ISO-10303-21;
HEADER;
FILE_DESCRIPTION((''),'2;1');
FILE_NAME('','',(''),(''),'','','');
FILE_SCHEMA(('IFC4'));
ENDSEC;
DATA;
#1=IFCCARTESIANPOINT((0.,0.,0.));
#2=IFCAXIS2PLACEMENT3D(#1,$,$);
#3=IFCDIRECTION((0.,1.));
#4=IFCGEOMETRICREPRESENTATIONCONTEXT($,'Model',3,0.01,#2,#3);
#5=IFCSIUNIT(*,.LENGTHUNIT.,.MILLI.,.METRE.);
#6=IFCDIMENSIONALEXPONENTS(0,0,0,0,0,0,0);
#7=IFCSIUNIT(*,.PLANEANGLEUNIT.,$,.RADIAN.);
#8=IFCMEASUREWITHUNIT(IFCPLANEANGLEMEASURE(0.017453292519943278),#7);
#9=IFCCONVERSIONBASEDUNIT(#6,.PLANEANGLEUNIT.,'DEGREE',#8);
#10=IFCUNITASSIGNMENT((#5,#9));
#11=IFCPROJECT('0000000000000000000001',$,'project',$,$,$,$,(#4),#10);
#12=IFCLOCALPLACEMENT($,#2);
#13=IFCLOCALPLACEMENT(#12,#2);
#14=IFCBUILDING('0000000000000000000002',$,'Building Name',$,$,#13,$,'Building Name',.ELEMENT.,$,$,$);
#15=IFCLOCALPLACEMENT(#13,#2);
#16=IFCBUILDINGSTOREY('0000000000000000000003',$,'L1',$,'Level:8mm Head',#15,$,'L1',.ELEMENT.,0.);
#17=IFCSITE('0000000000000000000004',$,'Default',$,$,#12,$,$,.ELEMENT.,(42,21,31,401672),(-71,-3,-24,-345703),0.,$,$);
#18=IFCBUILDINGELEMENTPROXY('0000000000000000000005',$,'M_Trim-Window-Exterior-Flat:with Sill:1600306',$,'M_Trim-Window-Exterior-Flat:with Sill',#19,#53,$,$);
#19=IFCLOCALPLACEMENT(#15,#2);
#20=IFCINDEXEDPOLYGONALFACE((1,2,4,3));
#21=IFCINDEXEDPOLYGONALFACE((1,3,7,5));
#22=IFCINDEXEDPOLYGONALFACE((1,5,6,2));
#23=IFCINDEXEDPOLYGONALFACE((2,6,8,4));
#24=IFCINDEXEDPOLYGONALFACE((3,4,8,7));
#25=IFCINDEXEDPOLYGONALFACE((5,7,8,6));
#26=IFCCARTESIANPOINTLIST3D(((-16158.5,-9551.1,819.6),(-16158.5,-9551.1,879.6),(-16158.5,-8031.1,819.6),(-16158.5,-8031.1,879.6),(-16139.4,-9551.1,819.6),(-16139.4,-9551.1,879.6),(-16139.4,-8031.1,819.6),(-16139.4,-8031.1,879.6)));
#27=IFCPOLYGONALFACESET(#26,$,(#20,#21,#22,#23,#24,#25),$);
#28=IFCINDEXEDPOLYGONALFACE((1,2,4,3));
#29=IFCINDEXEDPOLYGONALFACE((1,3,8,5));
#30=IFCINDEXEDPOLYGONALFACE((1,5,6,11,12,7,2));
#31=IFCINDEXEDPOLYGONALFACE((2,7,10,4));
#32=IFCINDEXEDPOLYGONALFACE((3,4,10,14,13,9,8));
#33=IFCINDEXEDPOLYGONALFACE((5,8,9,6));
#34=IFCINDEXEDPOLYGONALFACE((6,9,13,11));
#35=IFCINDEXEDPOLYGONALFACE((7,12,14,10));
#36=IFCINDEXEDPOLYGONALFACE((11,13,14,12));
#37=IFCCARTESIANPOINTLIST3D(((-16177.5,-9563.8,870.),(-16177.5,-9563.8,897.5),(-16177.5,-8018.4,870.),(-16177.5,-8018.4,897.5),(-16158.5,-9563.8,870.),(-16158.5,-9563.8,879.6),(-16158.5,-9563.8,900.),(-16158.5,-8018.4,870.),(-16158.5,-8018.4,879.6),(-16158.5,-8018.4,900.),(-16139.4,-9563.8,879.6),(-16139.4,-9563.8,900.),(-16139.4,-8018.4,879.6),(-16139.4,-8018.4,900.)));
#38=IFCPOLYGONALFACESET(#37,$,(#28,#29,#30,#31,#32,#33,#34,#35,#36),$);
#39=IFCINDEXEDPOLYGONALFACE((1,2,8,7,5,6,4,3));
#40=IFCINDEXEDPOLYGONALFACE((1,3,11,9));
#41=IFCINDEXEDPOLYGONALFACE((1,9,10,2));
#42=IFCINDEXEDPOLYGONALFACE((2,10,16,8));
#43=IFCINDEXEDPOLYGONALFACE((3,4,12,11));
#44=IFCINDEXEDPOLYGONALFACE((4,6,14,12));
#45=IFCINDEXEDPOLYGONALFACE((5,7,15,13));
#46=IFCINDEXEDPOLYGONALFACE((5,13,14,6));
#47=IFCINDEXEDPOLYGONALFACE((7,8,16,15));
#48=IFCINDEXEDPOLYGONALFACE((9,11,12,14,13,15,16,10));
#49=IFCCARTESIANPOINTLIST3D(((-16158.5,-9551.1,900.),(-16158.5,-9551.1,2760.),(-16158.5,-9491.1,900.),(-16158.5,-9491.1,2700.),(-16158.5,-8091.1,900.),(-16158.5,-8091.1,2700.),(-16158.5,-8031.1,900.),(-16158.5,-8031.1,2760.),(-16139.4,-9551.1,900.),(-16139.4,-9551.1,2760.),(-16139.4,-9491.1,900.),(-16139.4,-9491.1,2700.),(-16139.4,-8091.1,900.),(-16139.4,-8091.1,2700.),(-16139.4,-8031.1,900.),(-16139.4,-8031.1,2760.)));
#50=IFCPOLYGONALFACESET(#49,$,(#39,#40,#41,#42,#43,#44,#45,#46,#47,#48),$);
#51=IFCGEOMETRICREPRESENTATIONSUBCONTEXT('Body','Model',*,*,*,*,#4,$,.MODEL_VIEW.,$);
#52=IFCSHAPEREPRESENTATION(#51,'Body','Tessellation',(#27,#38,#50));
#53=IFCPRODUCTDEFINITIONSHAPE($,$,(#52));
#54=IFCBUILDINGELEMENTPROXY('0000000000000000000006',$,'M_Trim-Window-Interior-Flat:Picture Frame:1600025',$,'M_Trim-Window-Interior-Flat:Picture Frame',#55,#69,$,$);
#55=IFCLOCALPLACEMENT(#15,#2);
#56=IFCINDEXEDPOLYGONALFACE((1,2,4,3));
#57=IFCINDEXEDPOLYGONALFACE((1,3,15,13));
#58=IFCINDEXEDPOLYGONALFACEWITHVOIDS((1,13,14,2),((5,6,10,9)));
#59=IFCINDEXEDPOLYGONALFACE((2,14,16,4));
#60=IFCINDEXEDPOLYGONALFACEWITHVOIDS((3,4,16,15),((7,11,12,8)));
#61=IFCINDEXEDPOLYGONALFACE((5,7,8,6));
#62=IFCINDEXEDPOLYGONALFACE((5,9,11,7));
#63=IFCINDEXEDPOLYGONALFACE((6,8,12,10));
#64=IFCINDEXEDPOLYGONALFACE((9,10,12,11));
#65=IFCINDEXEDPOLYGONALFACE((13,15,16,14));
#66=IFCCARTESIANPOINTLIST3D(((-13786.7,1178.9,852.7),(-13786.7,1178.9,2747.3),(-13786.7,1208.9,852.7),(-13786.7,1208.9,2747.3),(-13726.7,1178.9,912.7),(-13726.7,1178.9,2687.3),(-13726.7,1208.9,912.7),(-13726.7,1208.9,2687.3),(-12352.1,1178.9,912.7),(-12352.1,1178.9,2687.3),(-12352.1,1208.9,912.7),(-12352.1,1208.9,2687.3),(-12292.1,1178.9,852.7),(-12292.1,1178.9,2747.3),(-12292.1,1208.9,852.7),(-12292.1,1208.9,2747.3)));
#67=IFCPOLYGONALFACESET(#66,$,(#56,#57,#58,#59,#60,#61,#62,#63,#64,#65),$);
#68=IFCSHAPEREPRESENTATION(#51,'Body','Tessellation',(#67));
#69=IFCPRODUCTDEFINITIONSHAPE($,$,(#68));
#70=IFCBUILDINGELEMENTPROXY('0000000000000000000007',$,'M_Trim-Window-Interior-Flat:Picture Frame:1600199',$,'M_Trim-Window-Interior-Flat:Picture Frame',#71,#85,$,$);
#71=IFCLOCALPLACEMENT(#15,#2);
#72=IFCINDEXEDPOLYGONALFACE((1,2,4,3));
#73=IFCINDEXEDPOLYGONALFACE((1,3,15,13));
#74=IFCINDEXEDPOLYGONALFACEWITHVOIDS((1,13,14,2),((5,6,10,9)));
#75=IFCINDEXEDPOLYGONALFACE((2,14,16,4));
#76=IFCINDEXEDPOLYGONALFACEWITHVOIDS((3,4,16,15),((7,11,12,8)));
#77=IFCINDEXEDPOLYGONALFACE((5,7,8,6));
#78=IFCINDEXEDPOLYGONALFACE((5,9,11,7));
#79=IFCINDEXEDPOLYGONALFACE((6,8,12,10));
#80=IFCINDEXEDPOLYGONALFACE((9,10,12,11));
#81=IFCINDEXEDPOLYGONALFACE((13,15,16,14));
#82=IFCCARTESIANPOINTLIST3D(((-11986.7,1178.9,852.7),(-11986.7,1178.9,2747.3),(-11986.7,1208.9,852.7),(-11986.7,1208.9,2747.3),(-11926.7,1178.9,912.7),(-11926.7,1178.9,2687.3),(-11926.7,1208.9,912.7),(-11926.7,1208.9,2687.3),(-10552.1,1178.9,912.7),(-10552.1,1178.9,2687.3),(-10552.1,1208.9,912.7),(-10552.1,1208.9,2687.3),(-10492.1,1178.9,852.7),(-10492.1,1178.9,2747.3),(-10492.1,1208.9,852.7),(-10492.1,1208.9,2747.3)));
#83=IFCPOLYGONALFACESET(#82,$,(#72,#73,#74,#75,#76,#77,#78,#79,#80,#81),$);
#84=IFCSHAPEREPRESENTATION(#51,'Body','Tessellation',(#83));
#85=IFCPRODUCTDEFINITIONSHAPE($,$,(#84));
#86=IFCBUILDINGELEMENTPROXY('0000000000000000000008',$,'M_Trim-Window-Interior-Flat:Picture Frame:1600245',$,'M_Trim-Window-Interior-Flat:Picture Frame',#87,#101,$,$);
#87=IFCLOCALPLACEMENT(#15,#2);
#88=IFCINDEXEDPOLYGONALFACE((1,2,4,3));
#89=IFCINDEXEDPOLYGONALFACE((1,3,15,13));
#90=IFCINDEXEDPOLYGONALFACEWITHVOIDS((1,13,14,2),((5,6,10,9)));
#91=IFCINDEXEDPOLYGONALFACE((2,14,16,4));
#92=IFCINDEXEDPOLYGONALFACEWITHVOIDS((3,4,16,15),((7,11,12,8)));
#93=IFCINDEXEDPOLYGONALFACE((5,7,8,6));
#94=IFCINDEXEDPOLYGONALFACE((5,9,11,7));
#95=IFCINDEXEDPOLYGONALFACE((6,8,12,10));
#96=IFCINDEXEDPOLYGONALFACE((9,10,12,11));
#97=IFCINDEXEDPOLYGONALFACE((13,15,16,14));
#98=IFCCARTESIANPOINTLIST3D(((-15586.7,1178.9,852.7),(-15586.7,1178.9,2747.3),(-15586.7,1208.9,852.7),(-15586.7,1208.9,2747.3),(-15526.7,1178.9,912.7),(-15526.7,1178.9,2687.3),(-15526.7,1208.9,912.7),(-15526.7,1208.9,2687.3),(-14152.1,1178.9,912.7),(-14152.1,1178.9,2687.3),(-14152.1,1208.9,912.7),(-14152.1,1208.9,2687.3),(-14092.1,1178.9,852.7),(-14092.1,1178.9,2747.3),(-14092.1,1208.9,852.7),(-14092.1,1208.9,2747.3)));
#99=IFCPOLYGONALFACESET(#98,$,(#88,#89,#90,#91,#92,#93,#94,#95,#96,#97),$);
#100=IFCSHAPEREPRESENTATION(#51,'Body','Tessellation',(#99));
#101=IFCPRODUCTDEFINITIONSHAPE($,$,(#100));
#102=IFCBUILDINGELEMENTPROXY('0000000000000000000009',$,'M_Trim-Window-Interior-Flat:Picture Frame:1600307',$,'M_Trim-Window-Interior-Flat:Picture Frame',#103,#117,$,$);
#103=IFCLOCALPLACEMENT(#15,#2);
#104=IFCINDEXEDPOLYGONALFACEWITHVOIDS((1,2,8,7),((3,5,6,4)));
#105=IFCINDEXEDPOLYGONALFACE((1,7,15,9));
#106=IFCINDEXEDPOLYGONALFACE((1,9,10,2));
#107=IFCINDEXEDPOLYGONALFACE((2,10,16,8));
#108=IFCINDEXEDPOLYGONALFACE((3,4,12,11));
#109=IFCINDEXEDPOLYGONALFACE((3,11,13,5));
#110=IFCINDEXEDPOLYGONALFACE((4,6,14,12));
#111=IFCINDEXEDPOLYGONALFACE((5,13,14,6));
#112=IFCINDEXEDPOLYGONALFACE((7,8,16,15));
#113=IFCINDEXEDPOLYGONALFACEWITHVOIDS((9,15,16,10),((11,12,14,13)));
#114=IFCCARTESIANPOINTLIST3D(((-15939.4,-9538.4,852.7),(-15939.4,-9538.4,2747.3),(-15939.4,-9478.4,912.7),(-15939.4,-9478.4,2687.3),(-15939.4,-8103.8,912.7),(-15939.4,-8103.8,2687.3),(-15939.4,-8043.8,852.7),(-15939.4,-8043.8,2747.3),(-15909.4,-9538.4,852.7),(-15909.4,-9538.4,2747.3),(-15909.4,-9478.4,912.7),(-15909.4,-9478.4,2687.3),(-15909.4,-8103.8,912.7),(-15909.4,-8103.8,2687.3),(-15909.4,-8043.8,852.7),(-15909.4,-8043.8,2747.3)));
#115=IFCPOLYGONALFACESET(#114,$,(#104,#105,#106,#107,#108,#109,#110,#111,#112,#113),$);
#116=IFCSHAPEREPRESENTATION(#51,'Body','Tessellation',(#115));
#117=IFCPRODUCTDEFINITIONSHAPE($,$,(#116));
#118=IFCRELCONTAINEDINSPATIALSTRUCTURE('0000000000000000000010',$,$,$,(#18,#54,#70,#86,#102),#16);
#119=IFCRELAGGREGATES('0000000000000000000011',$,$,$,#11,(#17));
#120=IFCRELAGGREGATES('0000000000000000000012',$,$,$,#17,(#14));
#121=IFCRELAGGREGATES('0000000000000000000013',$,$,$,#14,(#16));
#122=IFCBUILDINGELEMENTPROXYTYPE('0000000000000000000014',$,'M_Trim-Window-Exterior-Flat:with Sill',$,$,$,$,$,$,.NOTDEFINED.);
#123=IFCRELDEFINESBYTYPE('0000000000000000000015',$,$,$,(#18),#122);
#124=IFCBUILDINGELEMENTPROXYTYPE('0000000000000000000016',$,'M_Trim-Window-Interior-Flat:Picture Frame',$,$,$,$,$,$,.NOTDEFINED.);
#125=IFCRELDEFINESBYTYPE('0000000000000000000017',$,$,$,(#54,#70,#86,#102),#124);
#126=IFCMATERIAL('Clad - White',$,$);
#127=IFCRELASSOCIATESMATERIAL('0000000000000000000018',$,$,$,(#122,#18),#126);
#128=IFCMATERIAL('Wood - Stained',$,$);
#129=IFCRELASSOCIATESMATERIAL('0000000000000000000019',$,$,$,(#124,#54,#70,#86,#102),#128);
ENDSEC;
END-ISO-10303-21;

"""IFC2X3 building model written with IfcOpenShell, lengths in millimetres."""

from ifc_helpers import new_model, entity, si_unit, converted_unit, direction, frame, frame_2d, origin, place, context, subcontext, project, spatial, polyline, rectangle, outline, extrude, source, transform, mapped, material, type_object, type_shapes, element, save


model = new_model("IFC2X3")

# Units and contexts
model_context = context("Model", 3, precision=0.01, world=origin(), true_north=direction((0.0, 1.0)))
body_context = subcontext(model_context, "Body", "Model", "MODEL_VIEW")
ifc_project = project(units=[si_unit("LENGTHUNIT", "METRE", prefix="MILLI"), converted_unit("PLANEANGLEUNIT", "DEGREE", entity("IfcPlaneAngleMeasure", 0.017453292519943278), si_unit("PLANEANGLEUNIT", "RADIAN"), dimensions=[0, 0, 0, 0, 0, 0, 0])], contexts=[model_context])

# Site, building, storey
site_placement = place(None, origin())
site = spatial("IfcSite", under=ifc_project, at=site_placement, Name="Default", CompositionType="ELEMENT", RefLatitude=(42, 21, 31, 401672), RefLongitude=(-71, -3, -24, -345703), RefElevation=0.0)
building_placement = place(site_placement, origin())
building = spatial("IfcBuilding", under=site, at=building_placement, Name="Building Name", LongName="Building Name", CompositionType="ELEMENT")
storey_placement = place(building_placement, origin())
storey = spatial("IfcBuildingStorey", under=building, at=storey_placement, Name="L1", ObjectType="Level:8mm Head", LongName="L1", CompositionType="ELEMENT", Elevation=0.0)

# Building element proxies
ifc_material_1 = material(Name="Clad - White")
ifc_material_2 = material(Name="Wood - Stained")
building_element_proxy_type_1 = type_object("IfcBuildingElementProxyType", Name="M_Trim-Window-Exterior-Flat:with Sill", PredefinedType="NOTDEFINED", material=ifc_material_1)
shared_shape_1 = source(origin(), body_context, "Body", "SweptSolid", [
    extrude(rectangle(XDim=1520.0, YDim=60.0, at=frame_2d((0.0, 0.0), x_axis=(1.0, 0.0))), frame((0.0, -1850.4, 0.0), z_axis=(0.0, 0.0, 1.0), x_axis=(-1.0, 0.0, 0.0)), (0.0, 0.0, 1.0), 19.0),
    extrude(outline(polyline([(-19.0, -15.2), (0.0, -15.2), (0.0, -5.7), (19.0, -5.7), (19.0, 14.8), (0.0, 14.8), (-19.0, 12.3), (-19.0, -15.2)])), frame((-772.7, -1814.8, 19.0), z_axis=(1.0, 0.0, 0.0), x_axis=(0.0, 0.0, -1.0)), (0.0, 0.0, 1.0), 1545.4),
    extrude(outline(polyline([(-945.0, -760.0), (915.0, -760.0), (915.0, -700.0), (-885.0, -700.0), (-885.0, 700.0), (915.0, 700.0), (915.0, 760.0), (-945.0, 760.0), (-945.0, -760.0)])), frame((0.0, -885.0, 0.0), z_axis=(0.0, 0.0, 1.0), x_axis=(0.0, -1.0, 0.0)), (0.0, 0.0, 1.0), 19.0),
])
type_shapes(building_element_proxy_type_1, [shared_shape_1])
for number, where, z_axis, x_axis, name in (
    (1, (-16139.4, -8791.1, 2700.0), (-1.0, 0.0, 0.0), (0.0, -1.0, 0.0), "M_Trim-Window-Exterior-Flat:with Sill:1600306"),
):
    element("IfcBuildingElementProxy", number, at=place(storey_placement, frame(where, z_axis=z_axis, x_axis=x_axis)), inside=storey, type_object=building_element_proxy_type_1, material=ifc_material_1, Name=name, ObjectType="M_Trim-Window-Exterior-Flat:with Sill", context=body_context, shape_type="MappedRepresentation", body=[
        mapped(shared_shape_1, transform((0.0, 0.0, 0.0), scale=1.0)),
    ])
building_element_proxy_type_2 = type_object("IfcBuildingElementProxyType", Name="M_Trim-Window-Interior-Flat:Picture Frame", PredefinedType="NOTDEFINED", material=ifc_material_2)
shared_shape_2 = source(origin(), body_context, "Body", "SweptSolid", [
    extrude(outline(polyline([(-747.3, -947.3), (747.3, -947.3), (747.3, 947.3), (-747.3, 947.3), (-747.3, -947.3)]), holes=[polyline([(-687.3, -887.3), (-687.3, 887.3), (687.3, 887.3), (687.3, -887.3), (-687.3, -887.3)])]), frame((0.0, -900.0, 0.0), z_axis=(0.0, 0.0, 1.0), x_axis=(-1.0, 0.0, 0.0)), (0.0, 0.0, 1.0), 30.0),
])
type_shapes(building_element_proxy_type_2, [shared_shape_2])
for number, where, z_axis, x_axis, name in (
    (2, (-13039.4, 1208.9, 2700.0), (0.0, -1.0, 0.0), (1.0, 0.0, 0.0), "M_Trim-Window-Interior-Flat:Picture Frame:1600025"),
    (3, (-11239.4, 1208.9, 2700.0), (0.0, -1.0, 0.0), (1.0, 0.0, 0.0), "M_Trim-Window-Interior-Flat:Picture Frame:1600199"),
    (4, (-14839.4, 1208.9, 2700.0), (0.0, -1.0, 0.0), (1.0, 0.0, 0.0), "M_Trim-Window-Interior-Flat:Picture Frame:1600245"),
    (5, (-15939.4, -8791.1, 2700.0), (1.0, 0.0, 0.0), (0.0, 1.0, 0.0), "M_Trim-Window-Interior-Flat:Picture Frame:1600307"),
):
    element("IfcBuildingElementProxy", number, at=place(storey_placement, frame(where, z_axis=z_axis, x_axis=x_axis)), inside=storey, type_object=building_element_proxy_type_2, material=ifc_material_2, Name=name, ObjectType="M_Trim-Window-Interior-Flat:Picture Frame", context=body_context, shape_type="MappedRepresentation", body=[
        mapped(shared_shape_2, transform((0.0, 0.0, 0.0), scale=1.0)),
    ])

save(model, "model.ifc")
